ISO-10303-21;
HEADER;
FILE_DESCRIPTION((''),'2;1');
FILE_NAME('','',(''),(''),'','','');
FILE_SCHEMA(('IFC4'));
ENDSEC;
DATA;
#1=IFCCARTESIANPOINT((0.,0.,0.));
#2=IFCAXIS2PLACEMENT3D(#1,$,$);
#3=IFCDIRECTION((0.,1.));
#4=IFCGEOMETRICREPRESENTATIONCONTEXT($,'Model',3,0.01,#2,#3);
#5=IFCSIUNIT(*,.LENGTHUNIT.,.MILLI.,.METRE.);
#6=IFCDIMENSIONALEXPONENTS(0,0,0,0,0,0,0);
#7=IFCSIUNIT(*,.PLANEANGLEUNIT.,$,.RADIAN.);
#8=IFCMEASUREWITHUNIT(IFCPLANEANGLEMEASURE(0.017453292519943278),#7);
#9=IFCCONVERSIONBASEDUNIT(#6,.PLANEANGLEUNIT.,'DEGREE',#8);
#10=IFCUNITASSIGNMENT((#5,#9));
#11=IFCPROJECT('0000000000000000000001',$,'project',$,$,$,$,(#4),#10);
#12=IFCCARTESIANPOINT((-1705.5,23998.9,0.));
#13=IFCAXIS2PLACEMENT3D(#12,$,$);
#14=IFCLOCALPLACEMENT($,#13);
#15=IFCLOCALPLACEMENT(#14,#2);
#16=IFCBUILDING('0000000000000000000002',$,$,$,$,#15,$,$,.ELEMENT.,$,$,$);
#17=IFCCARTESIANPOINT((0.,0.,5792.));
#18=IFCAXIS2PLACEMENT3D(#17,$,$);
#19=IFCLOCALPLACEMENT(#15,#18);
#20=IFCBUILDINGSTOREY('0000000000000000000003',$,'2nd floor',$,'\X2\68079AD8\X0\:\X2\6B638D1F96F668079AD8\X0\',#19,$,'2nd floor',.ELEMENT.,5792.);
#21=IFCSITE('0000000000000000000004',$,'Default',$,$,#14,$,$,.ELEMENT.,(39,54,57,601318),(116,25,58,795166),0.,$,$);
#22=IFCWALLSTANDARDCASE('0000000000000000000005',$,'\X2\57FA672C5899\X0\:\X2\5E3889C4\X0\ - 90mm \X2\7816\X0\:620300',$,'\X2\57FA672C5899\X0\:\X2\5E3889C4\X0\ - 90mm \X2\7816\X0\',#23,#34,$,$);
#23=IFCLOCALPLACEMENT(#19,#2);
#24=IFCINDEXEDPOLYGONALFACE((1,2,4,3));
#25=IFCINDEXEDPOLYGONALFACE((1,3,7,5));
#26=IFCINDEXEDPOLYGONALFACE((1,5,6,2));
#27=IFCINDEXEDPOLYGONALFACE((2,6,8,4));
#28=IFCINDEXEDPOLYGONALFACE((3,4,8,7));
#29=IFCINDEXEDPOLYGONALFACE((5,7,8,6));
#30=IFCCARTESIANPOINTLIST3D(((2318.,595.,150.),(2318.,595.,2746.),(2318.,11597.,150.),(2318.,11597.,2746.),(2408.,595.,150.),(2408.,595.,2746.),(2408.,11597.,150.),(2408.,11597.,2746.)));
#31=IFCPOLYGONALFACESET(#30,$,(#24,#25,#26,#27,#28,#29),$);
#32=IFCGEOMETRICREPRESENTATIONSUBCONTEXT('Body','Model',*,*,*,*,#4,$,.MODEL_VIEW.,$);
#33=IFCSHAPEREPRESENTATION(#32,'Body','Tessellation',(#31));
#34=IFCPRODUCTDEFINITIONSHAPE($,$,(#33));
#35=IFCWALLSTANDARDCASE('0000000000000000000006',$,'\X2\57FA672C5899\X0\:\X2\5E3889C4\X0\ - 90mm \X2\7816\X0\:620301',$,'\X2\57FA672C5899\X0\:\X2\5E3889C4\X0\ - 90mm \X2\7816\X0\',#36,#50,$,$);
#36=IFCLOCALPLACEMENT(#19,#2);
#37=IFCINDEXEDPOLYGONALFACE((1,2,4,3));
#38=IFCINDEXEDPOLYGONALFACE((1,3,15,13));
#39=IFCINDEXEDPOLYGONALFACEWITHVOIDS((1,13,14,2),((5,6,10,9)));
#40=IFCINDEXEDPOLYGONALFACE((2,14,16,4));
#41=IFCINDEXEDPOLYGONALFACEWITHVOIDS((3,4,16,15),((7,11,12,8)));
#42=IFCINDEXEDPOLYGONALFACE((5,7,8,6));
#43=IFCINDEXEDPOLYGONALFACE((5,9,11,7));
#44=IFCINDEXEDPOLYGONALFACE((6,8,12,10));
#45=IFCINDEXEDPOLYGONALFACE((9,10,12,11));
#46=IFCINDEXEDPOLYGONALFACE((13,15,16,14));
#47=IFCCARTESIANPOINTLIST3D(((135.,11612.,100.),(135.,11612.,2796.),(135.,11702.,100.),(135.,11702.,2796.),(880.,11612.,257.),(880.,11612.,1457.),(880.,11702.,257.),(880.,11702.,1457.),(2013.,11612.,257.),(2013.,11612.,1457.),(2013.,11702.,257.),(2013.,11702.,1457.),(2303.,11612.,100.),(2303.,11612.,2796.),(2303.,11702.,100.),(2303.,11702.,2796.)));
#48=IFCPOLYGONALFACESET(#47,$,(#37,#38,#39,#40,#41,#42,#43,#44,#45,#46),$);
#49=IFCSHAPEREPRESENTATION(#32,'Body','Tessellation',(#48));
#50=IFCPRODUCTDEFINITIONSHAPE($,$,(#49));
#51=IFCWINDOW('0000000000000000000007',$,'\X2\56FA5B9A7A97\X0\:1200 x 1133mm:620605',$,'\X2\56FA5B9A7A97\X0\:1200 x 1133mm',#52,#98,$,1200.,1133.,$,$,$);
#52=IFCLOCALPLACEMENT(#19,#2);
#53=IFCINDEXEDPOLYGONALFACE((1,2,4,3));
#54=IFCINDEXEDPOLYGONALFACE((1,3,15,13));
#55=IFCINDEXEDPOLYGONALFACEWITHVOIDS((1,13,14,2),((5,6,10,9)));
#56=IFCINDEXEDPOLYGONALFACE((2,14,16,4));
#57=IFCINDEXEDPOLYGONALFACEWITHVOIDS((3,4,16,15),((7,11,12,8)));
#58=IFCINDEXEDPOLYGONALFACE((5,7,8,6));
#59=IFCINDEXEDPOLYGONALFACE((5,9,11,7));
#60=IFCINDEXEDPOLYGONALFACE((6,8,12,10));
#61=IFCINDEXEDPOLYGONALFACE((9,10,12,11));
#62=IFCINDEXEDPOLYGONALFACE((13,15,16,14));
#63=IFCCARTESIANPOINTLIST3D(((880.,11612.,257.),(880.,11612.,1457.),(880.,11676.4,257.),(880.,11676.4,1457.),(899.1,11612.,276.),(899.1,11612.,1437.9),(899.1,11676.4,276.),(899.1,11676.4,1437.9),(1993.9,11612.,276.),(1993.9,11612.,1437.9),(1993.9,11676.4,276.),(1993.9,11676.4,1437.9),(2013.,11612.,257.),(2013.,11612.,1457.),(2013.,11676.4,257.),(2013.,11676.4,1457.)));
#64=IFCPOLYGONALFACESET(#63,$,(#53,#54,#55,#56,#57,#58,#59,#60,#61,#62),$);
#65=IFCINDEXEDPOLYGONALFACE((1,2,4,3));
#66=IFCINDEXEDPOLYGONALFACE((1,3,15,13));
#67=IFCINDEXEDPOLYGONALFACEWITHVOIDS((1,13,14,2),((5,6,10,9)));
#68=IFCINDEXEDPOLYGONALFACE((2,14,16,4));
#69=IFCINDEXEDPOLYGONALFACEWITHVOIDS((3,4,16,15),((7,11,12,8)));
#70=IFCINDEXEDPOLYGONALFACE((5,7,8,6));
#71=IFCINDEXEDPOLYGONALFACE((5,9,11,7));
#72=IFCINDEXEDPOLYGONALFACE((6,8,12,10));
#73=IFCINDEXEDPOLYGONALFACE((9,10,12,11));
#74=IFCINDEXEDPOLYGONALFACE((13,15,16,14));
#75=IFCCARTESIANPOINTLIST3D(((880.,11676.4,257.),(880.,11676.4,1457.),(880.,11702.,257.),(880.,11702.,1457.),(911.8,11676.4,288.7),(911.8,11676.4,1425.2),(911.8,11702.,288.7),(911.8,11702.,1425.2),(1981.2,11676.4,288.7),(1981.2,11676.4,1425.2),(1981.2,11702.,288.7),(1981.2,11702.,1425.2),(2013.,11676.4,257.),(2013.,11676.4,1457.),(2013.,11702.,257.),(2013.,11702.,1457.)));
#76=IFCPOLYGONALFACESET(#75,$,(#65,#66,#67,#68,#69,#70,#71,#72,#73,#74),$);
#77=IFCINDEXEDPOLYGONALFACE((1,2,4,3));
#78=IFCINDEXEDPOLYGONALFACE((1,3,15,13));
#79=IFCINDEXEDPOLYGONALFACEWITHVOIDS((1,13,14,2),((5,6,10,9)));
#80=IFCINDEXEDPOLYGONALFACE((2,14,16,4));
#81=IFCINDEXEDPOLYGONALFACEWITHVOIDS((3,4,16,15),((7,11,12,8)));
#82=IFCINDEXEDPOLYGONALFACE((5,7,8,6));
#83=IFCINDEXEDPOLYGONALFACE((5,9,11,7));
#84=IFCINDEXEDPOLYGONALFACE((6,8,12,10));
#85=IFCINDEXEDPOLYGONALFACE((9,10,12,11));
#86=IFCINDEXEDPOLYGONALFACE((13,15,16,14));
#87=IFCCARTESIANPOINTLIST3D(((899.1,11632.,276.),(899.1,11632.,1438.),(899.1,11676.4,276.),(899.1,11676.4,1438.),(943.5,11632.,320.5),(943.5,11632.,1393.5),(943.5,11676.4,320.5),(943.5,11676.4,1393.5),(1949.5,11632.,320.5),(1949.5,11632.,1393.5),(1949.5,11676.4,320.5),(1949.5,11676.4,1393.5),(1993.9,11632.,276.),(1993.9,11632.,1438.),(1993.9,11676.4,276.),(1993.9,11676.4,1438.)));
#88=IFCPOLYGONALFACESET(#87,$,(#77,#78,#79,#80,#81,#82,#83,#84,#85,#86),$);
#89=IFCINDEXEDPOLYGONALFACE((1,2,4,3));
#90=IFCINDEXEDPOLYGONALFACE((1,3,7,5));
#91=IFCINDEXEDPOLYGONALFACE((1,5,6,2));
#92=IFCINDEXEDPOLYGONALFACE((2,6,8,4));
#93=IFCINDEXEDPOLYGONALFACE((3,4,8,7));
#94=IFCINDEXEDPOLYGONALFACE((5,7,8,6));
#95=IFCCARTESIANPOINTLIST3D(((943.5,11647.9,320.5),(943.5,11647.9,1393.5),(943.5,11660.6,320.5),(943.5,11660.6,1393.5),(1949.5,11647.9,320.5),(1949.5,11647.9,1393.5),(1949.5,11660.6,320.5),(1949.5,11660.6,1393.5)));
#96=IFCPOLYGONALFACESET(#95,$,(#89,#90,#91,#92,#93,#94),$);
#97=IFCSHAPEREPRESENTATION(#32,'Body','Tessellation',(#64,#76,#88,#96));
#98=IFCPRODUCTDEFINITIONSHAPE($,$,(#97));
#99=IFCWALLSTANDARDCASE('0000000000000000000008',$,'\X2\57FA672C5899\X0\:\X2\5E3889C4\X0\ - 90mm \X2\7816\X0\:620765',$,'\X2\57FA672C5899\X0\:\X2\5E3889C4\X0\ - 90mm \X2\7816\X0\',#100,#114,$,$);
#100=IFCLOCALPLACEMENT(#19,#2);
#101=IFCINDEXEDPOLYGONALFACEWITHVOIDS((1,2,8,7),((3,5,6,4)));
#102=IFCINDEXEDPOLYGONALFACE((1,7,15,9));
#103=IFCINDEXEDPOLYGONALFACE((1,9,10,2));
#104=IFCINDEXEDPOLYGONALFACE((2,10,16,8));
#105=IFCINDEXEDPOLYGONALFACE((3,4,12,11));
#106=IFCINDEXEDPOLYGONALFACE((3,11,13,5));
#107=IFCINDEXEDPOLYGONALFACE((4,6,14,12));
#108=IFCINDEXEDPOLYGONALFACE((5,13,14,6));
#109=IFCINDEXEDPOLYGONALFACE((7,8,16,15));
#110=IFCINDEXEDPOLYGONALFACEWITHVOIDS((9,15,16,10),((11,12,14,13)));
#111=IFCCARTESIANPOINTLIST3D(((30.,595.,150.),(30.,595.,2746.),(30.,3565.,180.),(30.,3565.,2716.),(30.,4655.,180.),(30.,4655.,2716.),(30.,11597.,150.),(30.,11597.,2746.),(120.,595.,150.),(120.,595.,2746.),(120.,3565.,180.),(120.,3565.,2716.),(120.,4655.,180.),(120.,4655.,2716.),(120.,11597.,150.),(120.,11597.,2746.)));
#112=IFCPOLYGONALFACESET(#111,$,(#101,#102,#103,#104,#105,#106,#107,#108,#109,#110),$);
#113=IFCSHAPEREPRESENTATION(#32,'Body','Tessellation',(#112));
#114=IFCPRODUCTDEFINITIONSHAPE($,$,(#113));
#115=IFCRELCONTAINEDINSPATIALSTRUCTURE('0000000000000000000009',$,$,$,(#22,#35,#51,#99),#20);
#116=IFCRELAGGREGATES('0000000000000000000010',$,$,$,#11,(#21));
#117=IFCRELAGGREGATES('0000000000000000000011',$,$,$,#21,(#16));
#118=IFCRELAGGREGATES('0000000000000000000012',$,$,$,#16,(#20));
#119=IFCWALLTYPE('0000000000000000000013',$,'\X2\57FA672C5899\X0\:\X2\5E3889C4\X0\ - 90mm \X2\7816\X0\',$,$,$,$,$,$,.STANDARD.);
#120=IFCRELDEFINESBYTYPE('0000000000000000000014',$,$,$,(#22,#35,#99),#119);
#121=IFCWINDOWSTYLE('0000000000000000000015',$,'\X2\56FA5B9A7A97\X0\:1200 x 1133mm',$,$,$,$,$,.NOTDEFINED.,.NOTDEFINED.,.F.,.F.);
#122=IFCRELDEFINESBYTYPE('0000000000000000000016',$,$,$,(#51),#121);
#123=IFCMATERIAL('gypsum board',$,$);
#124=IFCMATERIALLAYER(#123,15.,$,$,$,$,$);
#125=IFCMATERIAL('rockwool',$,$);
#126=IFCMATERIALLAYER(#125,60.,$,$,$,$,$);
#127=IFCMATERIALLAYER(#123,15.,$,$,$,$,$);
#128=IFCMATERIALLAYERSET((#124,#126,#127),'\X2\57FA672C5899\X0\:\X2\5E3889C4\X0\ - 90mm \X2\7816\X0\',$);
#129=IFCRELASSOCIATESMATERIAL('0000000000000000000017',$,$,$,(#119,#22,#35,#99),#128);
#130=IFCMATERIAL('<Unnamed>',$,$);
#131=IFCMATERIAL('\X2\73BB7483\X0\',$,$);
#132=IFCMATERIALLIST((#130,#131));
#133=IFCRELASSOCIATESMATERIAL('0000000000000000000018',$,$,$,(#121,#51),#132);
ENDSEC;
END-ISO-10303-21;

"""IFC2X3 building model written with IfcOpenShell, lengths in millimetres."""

from ifc_helpers import new_model, entity, si_unit, converted_unit, direction, frame, frame_2d, origin, origin_2d_with_axis, place, context, subcontext, project, spatial, polyline, rectangle, outline, extrude, source, transform, mapped, material, material_list, layer, layer_set, layer_usage, type_object, type_shapes, element, fill, save


model = new_model("IFC2X3")

# Units and contexts
model_context = context("Model", 3, precision=0.01, world=origin(), true_north=direction((0.0, 1.0)))
body_context = subcontext(model_context, "Body", "Model", "MODEL_VIEW")
ifc_project = project(units=[si_unit("LENGTHUNIT", "METRE", prefix="MILLI"), converted_unit("PLANEANGLEUNIT", "DEGREE", entity("IfcPlaneAngleMeasure", 0.017453292519943278), si_unit("PLANEANGLEUNIT", "RADIAN"), dimensions=[0, 0, 0, 0, 0, 0, 0])], contexts=[model_context])

# Site, building, storey
site_placement = place(None, frame((-1705.5, 23998.9, 0.0)))
site = spatial("IfcSite", under=ifc_project, at=site_placement, Name="Default", CompositionType="ELEMENT", RefLatitude=(39, 54, 57, 601318), RefLongitude=(116, 25, 58, 795166), RefElevation=0.0)
building_placement = place(site_placement, origin())
building = spatial("IfcBuilding", under=site, at=building_placement, CompositionType="ELEMENT")
storey_placement = place(building_placement, frame((0.0, 0.0, 5792.0)))
storey = spatial("IfcBuildingStorey", under=building, at=storey_placement, Name="2nd floor", ObjectType="标高:正负零标高", LongName="2nd floor", CompositionType="ELEMENT", Elevation=5792.0)

# Wall
ifc_material_1 = material(Name="gypsum board")
ifc_layer_1 = layer(ifc_material_1, 15.0)
ifc_material_2 = material(Name="rockwool")
ifc_layer_2 = layer(ifc_material_2, 60.0)
ifc_layer_3 = layer(ifc_material_1, 15.0)
ifc_layer_set = layer_set([ifc_layer_1, ifc_layer_2, ifc_layer_3], Name="基本墙:常规 - 90mm 砖")
ifc_layer_usage_1 = layer_usage(ifc_layer_set, "AXIS2", "NEGATIVE", 45.0)
wall_type = type_object("IfcWallType", Name="基本墙:常规 - 90mm 砖", PredefinedType="STANDARD", material=ifc_layer_set)
wall_1_placement = place(storey_placement, frame((2363.0, 11597.0, 150.0), z_axis=(0.0, 0.0, 1.0), x_axis=(0.0, -1.0, 0.0)))
element("IfcWallStandardCase", 1, at=wall_1_placement, inside=storey, type_object=wall_type, material=ifc_layer_usage_1, Name="基本墙:常规 - 90mm 砖:620300", ObjectType="基本墙:常规 - 90mm 砖", context=body_context, shape_type="SweptSolid", body=[
    extrude(rectangle(XDim=11002.0, YDim=90.0, at=frame_2d((5501.0, 0.0), x_axis=(-1.0, 0.0))), origin(), (0.0, 0.0, 1.0), 2596.0),
])

# Wall, opening, window
ifc_layer_usage_2 = layer_usage(ifc_layer_set, "AXIS2", "NEGATIVE", 45.0)
wall_2_placement = place(storey_placement, frame((2303.0, 11657.0, 100.0), z_axis=(0.0, 0.0, 1.0), x_axis=(-1.0, 0.0, 0.0)))
wall_2 = element("IfcWallStandardCase", 2, at=wall_2_placement, inside=storey, type_object=wall_type, material=ifc_layer_usage_2, Name="基本墙:常规 - 90mm 砖:620301", ObjectType="基本墙:常规 - 90mm 砖", context=body_context, shape_type="SweptSolid", body=[
    extrude(rectangle(XDim=2168.0, YDim=90.0, at=frame_2d((1084.0, 0.0), x_axis=(-1.0, 0.0))), origin(), (0.0, 0.0, 1.0), 2696.0),
])
opening_1_placement = place(wall_2_placement, frame((290.0, -45.0, 157.0)))
opening_1 = element("IfcOpeningElement", 3, at=opening_1_placement, cuts=wall_2, ObjectType="Opening", context=body_context, shape_type="SweptSolid", body=[
    extrude(rectangle(XDim=1200.0, YDim=1133.0, at=frame_2d((600.0, 566.5), x_axis=(-1.0, 0.0))), frame((0.0, 0.0, 0.0), z_axis=(0.0, 1.0, 0.0), x_axis=(0.0, 0.0, 1.0)), (0.0, 0.0, 1.0), 90.0),
])
ifc_material_3 = material(Name="<Unnamed>")
ifc_material_4 = material(Name="玻璃")
ifc_material_list = material_list([ifc_material_3, ifc_material_4])
window_style = type_object("IfcWindowStyle", Name="固定窗:1200 x 1133mm", ConstructionType="NOTDEFINED", OperationType="NOTDEFINED", ParameterTakesPrecedence=False, Sizeable=False, material=ifc_material_list)
shared_shape = source(origin(), body_context, "Body", "SweptSolid", [
    extrude(outline(polyline([(-600.0, -566.5), (600.0, -566.5), (600.0, 566.5), (-600.0, 566.5), (-600.0, -566.5)]), holes=[polyline([(-580.9, -547.4), (-580.9, 547.5), (581.0, 547.5), (581.0, -547.4), (-580.9, -547.4)])]), frame((566.5, 25.5, 600.0), z_axis=(0.0, 1.0, 0.0), x_axis=(0.0, 0.0, -1.0)), (0.0, 0.0, 1.0), 64.4),
    extrude(outline(polyline([(-566.5, -600.0), (566.5, -600.0), (566.5, 600.0), (-566.5, 600.0), (-566.5, -600.0)]), holes=[polyline([(-534.8, -568.2), (-534.8, 568.3), (534.7, 568.3), (534.7, -568.2), (-534.8, -568.2)])]), frame((566.5, 0.0, 600.0), z_axis=(0.0, 1.0, 0.0), x_axis=(1.0, 0.0, 0.0)), (0.0, 0.0, 1.0), 25.5),
    extrude(outline(polyline([(-547.4, -581.0), (547.4, -581.0), (547.4, 581.0), (-547.4, 581.0), (-547.4, -581.0)]), holes=[polyline([(-503.0, -536.5), (-503.0, 536.5), (503.0, 536.5), (503.0, -536.5), (-503.0, -536.5)])]), frame((566.5, 25.5, 600.0), z_axis=(0.0, 1.0, 0.0), x_axis=(1.0, 0.0, 0.0)), (0.0, 0.0, 1.0), 44.4),
    extrude(rectangle(XDim=12.7, YDim=1006.0, at=origin_2d_with_axis()), frame((566.5, 47.8, 63.5), z_axis=(0.0, 0.0, 1.0), x_axis=(0.0, 1.0, 0.0)), (0.0, 0.0, 1.0), 1073.0),
])
type_shapes(window_style, [shared_shape])
window_placement = place(opening_1_placement, origin())
window = element("IfcWindow", 4, at=window_placement, inside=storey, type_object=window_style, material=ifc_material_list, Name="固定窗:1200 x 1133mm:620605", ObjectType="固定窗:1200 x 1133mm", OverallHeight=1200.0, OverallWidth=1133.0, context=body_context, shape_type="MappedRepresentation", body=[
    mapped(shared_shape, transform((0.0, 0.0, 0.0), scale=1.0)),
])
fill(opening_1, window)

# Wall, opening
ifc_layer_usage_3 = layer_usage(ifc_layer_set, "AXIS2", "NEGATIVE", 45.0)
wall_3_placement = place(storey_placement, frame((75.0, 11597.0, 150.0), z_axis=(0.0, 0.0, 1.0), x_axis=(0.0, -1.0, 0.0)))
wall_3 = element("IfcWallStandardCase", 5, at=wall_3_placement, inside=storey, type_object=wall_type, material=ifc_layer_usage_3, Name="基本墙:常规 - 90mm 砖:620765", ObjectType="基本墙:常规 - 90mm 砖", context=body_context, shape_type="SweptSolid", body=[
    extrude(rectangle(XDim=11002.0, YDim=90.0, at=frame_2d((5501.0, 0.0), x_axis=(-1.0, 0.0))), origin(), (0.0, 0.0, 1.0), 2596.0),
])
opening_2_placement = place(wall_3_placement, origin())
element("IfcOpeningElement", 6, at=opening_2_placement, cuts=wall_3, ObjectType="Opening", context=body_context, shape_type="SweptSolid", body=[
    extrude(rectangle(XDim=2536.0, YDim=1090.0, at=frame_2d((0.0, 0.0), x_axis=(0.0, 1.0))), frame((7487.0, 45.0, 1298.0), z_axis=(0.0, -1.0, 0.0), x_axis=(-1.0, 0.0, 0.0)), (0.0, 0.0, 1.0), 90.0),
])

save(model, "model.ifc")
